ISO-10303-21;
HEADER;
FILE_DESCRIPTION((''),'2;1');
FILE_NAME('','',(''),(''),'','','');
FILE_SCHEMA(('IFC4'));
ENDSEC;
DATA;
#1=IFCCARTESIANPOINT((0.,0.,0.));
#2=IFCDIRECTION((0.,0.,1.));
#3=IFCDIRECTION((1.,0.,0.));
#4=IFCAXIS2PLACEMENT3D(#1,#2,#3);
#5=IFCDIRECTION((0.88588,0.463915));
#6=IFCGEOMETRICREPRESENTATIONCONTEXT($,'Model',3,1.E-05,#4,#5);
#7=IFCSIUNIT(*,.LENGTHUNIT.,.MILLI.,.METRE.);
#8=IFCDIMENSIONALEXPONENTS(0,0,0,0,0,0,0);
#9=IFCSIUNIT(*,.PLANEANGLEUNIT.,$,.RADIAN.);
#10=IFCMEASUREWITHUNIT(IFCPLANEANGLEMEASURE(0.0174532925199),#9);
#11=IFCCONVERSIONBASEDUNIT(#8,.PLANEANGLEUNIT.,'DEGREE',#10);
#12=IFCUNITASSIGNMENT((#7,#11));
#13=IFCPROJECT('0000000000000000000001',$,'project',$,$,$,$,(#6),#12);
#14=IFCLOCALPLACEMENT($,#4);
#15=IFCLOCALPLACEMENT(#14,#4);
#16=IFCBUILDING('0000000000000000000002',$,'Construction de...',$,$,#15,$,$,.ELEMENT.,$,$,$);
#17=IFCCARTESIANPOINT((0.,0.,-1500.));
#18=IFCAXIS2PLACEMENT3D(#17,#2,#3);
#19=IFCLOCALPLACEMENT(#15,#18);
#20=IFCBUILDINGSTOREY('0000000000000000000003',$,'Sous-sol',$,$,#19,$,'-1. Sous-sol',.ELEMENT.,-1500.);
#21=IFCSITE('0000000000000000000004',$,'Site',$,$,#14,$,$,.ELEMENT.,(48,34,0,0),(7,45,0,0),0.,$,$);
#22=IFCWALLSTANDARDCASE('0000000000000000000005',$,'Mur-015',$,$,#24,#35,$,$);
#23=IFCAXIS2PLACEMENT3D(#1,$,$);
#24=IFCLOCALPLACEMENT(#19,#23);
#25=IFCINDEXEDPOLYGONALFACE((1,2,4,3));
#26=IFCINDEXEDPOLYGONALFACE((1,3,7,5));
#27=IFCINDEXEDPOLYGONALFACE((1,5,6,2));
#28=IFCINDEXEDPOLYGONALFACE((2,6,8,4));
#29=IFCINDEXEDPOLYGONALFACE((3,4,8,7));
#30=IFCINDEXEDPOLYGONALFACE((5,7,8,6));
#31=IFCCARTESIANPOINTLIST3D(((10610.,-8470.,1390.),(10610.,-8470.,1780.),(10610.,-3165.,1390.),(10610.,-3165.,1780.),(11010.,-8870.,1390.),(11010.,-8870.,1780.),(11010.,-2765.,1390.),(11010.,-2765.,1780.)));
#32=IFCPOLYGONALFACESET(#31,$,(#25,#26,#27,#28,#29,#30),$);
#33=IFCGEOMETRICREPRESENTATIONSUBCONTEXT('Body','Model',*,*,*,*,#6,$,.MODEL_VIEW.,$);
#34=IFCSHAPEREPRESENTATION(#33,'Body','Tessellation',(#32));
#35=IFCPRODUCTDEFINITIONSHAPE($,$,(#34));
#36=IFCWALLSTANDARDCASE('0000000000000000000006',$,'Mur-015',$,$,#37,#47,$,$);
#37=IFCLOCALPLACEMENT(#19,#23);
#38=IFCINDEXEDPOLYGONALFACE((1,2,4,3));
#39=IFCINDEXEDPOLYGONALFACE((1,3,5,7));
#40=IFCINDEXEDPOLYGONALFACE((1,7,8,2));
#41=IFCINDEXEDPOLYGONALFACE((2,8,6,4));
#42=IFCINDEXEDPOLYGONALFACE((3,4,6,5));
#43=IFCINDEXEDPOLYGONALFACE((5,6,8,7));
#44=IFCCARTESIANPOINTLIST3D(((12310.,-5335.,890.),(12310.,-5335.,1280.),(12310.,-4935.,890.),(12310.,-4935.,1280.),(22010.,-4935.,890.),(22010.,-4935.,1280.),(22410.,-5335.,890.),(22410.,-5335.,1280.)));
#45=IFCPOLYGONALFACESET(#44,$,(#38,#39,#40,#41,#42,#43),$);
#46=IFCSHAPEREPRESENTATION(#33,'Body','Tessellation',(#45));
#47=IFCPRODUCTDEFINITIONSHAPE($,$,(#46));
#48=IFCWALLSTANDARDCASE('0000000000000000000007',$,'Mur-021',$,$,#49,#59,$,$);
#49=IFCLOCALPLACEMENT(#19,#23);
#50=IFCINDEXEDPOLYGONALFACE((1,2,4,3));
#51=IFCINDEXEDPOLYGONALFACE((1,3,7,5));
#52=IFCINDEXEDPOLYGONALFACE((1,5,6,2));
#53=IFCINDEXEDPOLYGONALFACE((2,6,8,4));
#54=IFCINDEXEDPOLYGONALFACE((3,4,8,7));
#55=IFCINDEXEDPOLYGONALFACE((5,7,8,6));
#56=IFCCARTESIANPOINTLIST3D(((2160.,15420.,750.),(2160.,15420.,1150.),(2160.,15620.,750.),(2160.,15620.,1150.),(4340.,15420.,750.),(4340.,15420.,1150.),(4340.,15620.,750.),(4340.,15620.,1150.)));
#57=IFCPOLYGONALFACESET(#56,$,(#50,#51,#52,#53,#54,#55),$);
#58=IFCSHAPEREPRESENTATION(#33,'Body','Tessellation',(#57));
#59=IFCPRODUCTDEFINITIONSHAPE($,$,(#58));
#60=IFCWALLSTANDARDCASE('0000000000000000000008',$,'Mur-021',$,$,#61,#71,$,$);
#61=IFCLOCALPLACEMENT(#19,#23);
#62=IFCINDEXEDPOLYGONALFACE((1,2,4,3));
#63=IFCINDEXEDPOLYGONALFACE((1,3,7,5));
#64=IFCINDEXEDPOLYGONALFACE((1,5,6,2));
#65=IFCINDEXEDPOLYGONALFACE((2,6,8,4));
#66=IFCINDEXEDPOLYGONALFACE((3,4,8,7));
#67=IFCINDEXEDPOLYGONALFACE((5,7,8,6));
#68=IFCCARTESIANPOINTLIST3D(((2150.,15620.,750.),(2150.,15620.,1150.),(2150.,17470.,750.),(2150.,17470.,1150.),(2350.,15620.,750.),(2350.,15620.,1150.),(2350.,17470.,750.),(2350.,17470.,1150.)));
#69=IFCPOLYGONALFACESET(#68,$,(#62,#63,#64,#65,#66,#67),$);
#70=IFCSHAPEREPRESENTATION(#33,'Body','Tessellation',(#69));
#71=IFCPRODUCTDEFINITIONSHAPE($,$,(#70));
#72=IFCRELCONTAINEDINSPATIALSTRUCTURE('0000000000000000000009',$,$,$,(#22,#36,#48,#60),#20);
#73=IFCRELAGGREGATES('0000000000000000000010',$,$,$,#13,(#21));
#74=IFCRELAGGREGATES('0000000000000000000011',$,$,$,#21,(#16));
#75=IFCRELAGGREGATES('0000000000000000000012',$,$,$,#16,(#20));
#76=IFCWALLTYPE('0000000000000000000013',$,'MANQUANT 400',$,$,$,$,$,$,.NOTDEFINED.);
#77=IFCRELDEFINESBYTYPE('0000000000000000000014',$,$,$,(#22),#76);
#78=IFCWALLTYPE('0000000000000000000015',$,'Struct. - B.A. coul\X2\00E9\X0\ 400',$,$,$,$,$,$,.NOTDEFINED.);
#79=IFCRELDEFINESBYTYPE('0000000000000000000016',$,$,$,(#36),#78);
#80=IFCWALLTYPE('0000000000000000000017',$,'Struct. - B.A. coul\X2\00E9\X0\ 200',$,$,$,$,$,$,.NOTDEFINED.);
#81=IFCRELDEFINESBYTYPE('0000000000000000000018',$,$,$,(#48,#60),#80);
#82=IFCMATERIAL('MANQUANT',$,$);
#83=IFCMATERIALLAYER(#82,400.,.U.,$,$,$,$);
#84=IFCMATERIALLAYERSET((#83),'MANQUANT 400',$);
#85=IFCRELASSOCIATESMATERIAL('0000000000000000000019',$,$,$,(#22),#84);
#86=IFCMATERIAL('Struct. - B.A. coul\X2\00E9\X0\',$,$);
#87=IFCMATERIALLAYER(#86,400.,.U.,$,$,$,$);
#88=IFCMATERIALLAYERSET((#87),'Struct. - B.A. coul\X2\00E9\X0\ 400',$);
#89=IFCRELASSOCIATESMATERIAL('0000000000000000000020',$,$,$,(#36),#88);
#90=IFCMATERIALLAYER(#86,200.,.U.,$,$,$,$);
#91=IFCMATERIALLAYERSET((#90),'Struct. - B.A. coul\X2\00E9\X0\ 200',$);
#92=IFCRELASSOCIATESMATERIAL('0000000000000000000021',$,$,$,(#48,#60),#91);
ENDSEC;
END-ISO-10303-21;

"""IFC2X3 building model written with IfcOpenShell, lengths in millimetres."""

from ifc_helpers import new_model, entity, si_unit, converted_unit, direction, frame, origin_with_axes, place, context, subcontext, project, spatial, polyline, outline, extrude, material, layer, layer_set, layer_usage, type_object, element, save


model = new_model("IFC2X3")

# Units and contexts
model_context = context("Model", 3, precision=1e-05, world=origin_with_axes(), true_north=direction((0.88588, 0.463915)))
body_context = subcontext(model_context, "Body", "Model", "MODEL_VIEW")
ifc_project = project(units=[si_unit("LENGTHUNIT", "METRE", prefix="MILLI"), converted_unit("PLANEANGLEUNIT", "DEGREE", entity("IfcPlaneAngleMeasure", 0.0174532925199), si_unit("PLANEANGLEUNIT", "RADIAN"), dimensions=[0, 0, 0, 0, 0, 0, 0])], contexts=[model_context])

# Site, building, storey
site_placement = place(None, origin_with_axes())
site = spatial("IfcSite", under=ifc_project, at=site_placement, Name="Site", CompositionType="ELEMENT", RefLatitude=(48, 34, 0, 0), RefLongitude=(7, 45, 0, 0), RefElevation=0.0)
building_placement = place(site_placement, origin_with_axes())
building = spatial("IfcBuilding", under=site, at=building_placement, Name="Construction de...", CompositionType="ELEMENT")
storey_placement = place(building_placement, frame((0.0, 0.0, -1500.0), z_axis=(0.0, 0.0, 1.0), x_axis=(1.0, 0.0, 0.0)))
storey = spatial("IfcBuildingStorey", under=building, at=storey_placement, Name="Sous-sol", LongName="-1. Sous-sol", CompositionType="ELEMENT", Elevation=-1500.0)

# Shared definitions
ifc_material_1 = material(Name="Struct. - B.A. coulé")

# Walls
ifc_material_2 = material(Name="MANQUANT")
ifc_layer_1 = layer(ifc_material_2, 400.0, ventilated="UNKNOWN")
ifc_layer_set_1 = layer_set([ifc_layer_1], Name="MANQUANT 400")
wall_type_1 = type_object("IfcWallType", Name="MANQUANT 400", PredefinedType="NOTDEFINED")
ifc_layer_usage_1 = layer_usage(ifc_layer_set_1, "AXIS2", "POSITIVE", -200.0)
wall_1_placement = place(storey_placement, frame((10810.0, -2965.0, 1390.0), z_axis=(0.0, 0.0, 1.0), x_axis=(0.0, -1.0, 0.0)))
element("IfcWallStandardCase", 1, at=wall_1_placement, inside=storey, type_object=wall_type_1, material=ifc_layer_usage_1, Name="Mur-015", context=body_context, shape_type="SweptSolid", body=[
    extrude(outline(polyline([(200.0, -200.0), (5505.0, -200.0), (5905.0, 200.0), (-200.0, 200.0), (200.0, -200.0)])), origin_with_axes(), (0.0, 0.0, 1.0), 390.0),
])
ifc_layer_2 = layer(ifc_material_1, 400.0, ventilated="UNKNOWN")
ifc_layer_set_2 = layer_set([ifc_layer_2], Name="Struct. - B.A. coulé 400")
ifc_layer_usage_2 = layer_usage(ifc_layer_set_2, "AXIS2", "NEGATIVE", 200.0)
wall_type_2 = type_object("IfcWallType", Name="Struct. - B.A. coulé 400", PredefinedType="NOTDEFINED")
wall_2_placement = place(storey_placement, frame((12310.0, -5135.0, 890.0), z_axis=(0.0, 0.0, 1.0), x_axis=(1.0, 0.0, 0.0)))
element("IfcWallStandardCase", 2, at=wall_2_placement, inside=storey, type_object=wall_type_2, material=ifc_layer_usage_2, Name="Mur-015", context=body_context, shape_type="SweptSolid", body=[
    extrude(outline(polyline([(0.0, -200.0), (10100.0, -200.0), (9700.0, 200.0), (0.0, 200.0), (0.0, -200.0)])), origin_with_axes(), (0.0, 0.0, 1.0), 390.0),
])
ifc_layer_3 = layer(ifc_material_1, 200.0, ventilated="UNKNOWN")
ifc_layer_set_3 = layer_set([ifc_layer_3], Name="Struct. - B.A. coulé 200")
ifc_layer_usage_3 = layer_usage(ifc_layer_set_3, "AXIS2", "NEGATIVE", 100.0)
wall_type_3 = type_object("IfcWallType", Name="Struct. - B.A. coulé 200", PredefinedType="NOTDEFINED")
wall_3_placement = place(storey_placement, frame((4340.0, 15520.0, 750.0), z_axis=(0.0, 0.0, 1.0), x_axis=(-1.0, 0.0, 0.0)))
element("IfcWallStandardCase", 3, at=wall_3_placement, inside=storey, type_object=wall_type_3, material=ifc_layer_usage_3, Name="Mur-021", context=body_context, shape_type="SweptSolid", body=[
    extrude(outline(polyline([(0.0, -100.0), (2180.0, -100.0), (2180.0, 100.0), (0.0, 100.0), (0.0, -100.0)])), origin_with_axes(), (0.0, 0.0, 1.0), 400.0),
])
ifc_layer_usage_4 = layer_usage(ifc_layer_set_3, "AXIS2", "NEGATIVE", 100.0)
wall_4_placement = place(storey_placement, frame((2250.0, 15520.0, 750.0), z_axis=(0.0, 0.0, 1.0), x_axis=(0.0, 1.0, 0.0)))
element("IfcWallStandardCase", 4, at=wall_4_placement, inside=storey, type_object=wall_type_3, material=ifc_layer_usage_4, Name="Mur-021", context=body_context, shape_type="SweptSolid", body=[
    extrude(outline(polyline([(100.0, -100.0), (1950.0, -100.0), (1950.0, 100.0), (100.0, 100.0), (100.0, -100.0)])), origin_with_axes(), (0.0, 0.0, 1.0), 400.0),
])

save(model, "model.ifc")
